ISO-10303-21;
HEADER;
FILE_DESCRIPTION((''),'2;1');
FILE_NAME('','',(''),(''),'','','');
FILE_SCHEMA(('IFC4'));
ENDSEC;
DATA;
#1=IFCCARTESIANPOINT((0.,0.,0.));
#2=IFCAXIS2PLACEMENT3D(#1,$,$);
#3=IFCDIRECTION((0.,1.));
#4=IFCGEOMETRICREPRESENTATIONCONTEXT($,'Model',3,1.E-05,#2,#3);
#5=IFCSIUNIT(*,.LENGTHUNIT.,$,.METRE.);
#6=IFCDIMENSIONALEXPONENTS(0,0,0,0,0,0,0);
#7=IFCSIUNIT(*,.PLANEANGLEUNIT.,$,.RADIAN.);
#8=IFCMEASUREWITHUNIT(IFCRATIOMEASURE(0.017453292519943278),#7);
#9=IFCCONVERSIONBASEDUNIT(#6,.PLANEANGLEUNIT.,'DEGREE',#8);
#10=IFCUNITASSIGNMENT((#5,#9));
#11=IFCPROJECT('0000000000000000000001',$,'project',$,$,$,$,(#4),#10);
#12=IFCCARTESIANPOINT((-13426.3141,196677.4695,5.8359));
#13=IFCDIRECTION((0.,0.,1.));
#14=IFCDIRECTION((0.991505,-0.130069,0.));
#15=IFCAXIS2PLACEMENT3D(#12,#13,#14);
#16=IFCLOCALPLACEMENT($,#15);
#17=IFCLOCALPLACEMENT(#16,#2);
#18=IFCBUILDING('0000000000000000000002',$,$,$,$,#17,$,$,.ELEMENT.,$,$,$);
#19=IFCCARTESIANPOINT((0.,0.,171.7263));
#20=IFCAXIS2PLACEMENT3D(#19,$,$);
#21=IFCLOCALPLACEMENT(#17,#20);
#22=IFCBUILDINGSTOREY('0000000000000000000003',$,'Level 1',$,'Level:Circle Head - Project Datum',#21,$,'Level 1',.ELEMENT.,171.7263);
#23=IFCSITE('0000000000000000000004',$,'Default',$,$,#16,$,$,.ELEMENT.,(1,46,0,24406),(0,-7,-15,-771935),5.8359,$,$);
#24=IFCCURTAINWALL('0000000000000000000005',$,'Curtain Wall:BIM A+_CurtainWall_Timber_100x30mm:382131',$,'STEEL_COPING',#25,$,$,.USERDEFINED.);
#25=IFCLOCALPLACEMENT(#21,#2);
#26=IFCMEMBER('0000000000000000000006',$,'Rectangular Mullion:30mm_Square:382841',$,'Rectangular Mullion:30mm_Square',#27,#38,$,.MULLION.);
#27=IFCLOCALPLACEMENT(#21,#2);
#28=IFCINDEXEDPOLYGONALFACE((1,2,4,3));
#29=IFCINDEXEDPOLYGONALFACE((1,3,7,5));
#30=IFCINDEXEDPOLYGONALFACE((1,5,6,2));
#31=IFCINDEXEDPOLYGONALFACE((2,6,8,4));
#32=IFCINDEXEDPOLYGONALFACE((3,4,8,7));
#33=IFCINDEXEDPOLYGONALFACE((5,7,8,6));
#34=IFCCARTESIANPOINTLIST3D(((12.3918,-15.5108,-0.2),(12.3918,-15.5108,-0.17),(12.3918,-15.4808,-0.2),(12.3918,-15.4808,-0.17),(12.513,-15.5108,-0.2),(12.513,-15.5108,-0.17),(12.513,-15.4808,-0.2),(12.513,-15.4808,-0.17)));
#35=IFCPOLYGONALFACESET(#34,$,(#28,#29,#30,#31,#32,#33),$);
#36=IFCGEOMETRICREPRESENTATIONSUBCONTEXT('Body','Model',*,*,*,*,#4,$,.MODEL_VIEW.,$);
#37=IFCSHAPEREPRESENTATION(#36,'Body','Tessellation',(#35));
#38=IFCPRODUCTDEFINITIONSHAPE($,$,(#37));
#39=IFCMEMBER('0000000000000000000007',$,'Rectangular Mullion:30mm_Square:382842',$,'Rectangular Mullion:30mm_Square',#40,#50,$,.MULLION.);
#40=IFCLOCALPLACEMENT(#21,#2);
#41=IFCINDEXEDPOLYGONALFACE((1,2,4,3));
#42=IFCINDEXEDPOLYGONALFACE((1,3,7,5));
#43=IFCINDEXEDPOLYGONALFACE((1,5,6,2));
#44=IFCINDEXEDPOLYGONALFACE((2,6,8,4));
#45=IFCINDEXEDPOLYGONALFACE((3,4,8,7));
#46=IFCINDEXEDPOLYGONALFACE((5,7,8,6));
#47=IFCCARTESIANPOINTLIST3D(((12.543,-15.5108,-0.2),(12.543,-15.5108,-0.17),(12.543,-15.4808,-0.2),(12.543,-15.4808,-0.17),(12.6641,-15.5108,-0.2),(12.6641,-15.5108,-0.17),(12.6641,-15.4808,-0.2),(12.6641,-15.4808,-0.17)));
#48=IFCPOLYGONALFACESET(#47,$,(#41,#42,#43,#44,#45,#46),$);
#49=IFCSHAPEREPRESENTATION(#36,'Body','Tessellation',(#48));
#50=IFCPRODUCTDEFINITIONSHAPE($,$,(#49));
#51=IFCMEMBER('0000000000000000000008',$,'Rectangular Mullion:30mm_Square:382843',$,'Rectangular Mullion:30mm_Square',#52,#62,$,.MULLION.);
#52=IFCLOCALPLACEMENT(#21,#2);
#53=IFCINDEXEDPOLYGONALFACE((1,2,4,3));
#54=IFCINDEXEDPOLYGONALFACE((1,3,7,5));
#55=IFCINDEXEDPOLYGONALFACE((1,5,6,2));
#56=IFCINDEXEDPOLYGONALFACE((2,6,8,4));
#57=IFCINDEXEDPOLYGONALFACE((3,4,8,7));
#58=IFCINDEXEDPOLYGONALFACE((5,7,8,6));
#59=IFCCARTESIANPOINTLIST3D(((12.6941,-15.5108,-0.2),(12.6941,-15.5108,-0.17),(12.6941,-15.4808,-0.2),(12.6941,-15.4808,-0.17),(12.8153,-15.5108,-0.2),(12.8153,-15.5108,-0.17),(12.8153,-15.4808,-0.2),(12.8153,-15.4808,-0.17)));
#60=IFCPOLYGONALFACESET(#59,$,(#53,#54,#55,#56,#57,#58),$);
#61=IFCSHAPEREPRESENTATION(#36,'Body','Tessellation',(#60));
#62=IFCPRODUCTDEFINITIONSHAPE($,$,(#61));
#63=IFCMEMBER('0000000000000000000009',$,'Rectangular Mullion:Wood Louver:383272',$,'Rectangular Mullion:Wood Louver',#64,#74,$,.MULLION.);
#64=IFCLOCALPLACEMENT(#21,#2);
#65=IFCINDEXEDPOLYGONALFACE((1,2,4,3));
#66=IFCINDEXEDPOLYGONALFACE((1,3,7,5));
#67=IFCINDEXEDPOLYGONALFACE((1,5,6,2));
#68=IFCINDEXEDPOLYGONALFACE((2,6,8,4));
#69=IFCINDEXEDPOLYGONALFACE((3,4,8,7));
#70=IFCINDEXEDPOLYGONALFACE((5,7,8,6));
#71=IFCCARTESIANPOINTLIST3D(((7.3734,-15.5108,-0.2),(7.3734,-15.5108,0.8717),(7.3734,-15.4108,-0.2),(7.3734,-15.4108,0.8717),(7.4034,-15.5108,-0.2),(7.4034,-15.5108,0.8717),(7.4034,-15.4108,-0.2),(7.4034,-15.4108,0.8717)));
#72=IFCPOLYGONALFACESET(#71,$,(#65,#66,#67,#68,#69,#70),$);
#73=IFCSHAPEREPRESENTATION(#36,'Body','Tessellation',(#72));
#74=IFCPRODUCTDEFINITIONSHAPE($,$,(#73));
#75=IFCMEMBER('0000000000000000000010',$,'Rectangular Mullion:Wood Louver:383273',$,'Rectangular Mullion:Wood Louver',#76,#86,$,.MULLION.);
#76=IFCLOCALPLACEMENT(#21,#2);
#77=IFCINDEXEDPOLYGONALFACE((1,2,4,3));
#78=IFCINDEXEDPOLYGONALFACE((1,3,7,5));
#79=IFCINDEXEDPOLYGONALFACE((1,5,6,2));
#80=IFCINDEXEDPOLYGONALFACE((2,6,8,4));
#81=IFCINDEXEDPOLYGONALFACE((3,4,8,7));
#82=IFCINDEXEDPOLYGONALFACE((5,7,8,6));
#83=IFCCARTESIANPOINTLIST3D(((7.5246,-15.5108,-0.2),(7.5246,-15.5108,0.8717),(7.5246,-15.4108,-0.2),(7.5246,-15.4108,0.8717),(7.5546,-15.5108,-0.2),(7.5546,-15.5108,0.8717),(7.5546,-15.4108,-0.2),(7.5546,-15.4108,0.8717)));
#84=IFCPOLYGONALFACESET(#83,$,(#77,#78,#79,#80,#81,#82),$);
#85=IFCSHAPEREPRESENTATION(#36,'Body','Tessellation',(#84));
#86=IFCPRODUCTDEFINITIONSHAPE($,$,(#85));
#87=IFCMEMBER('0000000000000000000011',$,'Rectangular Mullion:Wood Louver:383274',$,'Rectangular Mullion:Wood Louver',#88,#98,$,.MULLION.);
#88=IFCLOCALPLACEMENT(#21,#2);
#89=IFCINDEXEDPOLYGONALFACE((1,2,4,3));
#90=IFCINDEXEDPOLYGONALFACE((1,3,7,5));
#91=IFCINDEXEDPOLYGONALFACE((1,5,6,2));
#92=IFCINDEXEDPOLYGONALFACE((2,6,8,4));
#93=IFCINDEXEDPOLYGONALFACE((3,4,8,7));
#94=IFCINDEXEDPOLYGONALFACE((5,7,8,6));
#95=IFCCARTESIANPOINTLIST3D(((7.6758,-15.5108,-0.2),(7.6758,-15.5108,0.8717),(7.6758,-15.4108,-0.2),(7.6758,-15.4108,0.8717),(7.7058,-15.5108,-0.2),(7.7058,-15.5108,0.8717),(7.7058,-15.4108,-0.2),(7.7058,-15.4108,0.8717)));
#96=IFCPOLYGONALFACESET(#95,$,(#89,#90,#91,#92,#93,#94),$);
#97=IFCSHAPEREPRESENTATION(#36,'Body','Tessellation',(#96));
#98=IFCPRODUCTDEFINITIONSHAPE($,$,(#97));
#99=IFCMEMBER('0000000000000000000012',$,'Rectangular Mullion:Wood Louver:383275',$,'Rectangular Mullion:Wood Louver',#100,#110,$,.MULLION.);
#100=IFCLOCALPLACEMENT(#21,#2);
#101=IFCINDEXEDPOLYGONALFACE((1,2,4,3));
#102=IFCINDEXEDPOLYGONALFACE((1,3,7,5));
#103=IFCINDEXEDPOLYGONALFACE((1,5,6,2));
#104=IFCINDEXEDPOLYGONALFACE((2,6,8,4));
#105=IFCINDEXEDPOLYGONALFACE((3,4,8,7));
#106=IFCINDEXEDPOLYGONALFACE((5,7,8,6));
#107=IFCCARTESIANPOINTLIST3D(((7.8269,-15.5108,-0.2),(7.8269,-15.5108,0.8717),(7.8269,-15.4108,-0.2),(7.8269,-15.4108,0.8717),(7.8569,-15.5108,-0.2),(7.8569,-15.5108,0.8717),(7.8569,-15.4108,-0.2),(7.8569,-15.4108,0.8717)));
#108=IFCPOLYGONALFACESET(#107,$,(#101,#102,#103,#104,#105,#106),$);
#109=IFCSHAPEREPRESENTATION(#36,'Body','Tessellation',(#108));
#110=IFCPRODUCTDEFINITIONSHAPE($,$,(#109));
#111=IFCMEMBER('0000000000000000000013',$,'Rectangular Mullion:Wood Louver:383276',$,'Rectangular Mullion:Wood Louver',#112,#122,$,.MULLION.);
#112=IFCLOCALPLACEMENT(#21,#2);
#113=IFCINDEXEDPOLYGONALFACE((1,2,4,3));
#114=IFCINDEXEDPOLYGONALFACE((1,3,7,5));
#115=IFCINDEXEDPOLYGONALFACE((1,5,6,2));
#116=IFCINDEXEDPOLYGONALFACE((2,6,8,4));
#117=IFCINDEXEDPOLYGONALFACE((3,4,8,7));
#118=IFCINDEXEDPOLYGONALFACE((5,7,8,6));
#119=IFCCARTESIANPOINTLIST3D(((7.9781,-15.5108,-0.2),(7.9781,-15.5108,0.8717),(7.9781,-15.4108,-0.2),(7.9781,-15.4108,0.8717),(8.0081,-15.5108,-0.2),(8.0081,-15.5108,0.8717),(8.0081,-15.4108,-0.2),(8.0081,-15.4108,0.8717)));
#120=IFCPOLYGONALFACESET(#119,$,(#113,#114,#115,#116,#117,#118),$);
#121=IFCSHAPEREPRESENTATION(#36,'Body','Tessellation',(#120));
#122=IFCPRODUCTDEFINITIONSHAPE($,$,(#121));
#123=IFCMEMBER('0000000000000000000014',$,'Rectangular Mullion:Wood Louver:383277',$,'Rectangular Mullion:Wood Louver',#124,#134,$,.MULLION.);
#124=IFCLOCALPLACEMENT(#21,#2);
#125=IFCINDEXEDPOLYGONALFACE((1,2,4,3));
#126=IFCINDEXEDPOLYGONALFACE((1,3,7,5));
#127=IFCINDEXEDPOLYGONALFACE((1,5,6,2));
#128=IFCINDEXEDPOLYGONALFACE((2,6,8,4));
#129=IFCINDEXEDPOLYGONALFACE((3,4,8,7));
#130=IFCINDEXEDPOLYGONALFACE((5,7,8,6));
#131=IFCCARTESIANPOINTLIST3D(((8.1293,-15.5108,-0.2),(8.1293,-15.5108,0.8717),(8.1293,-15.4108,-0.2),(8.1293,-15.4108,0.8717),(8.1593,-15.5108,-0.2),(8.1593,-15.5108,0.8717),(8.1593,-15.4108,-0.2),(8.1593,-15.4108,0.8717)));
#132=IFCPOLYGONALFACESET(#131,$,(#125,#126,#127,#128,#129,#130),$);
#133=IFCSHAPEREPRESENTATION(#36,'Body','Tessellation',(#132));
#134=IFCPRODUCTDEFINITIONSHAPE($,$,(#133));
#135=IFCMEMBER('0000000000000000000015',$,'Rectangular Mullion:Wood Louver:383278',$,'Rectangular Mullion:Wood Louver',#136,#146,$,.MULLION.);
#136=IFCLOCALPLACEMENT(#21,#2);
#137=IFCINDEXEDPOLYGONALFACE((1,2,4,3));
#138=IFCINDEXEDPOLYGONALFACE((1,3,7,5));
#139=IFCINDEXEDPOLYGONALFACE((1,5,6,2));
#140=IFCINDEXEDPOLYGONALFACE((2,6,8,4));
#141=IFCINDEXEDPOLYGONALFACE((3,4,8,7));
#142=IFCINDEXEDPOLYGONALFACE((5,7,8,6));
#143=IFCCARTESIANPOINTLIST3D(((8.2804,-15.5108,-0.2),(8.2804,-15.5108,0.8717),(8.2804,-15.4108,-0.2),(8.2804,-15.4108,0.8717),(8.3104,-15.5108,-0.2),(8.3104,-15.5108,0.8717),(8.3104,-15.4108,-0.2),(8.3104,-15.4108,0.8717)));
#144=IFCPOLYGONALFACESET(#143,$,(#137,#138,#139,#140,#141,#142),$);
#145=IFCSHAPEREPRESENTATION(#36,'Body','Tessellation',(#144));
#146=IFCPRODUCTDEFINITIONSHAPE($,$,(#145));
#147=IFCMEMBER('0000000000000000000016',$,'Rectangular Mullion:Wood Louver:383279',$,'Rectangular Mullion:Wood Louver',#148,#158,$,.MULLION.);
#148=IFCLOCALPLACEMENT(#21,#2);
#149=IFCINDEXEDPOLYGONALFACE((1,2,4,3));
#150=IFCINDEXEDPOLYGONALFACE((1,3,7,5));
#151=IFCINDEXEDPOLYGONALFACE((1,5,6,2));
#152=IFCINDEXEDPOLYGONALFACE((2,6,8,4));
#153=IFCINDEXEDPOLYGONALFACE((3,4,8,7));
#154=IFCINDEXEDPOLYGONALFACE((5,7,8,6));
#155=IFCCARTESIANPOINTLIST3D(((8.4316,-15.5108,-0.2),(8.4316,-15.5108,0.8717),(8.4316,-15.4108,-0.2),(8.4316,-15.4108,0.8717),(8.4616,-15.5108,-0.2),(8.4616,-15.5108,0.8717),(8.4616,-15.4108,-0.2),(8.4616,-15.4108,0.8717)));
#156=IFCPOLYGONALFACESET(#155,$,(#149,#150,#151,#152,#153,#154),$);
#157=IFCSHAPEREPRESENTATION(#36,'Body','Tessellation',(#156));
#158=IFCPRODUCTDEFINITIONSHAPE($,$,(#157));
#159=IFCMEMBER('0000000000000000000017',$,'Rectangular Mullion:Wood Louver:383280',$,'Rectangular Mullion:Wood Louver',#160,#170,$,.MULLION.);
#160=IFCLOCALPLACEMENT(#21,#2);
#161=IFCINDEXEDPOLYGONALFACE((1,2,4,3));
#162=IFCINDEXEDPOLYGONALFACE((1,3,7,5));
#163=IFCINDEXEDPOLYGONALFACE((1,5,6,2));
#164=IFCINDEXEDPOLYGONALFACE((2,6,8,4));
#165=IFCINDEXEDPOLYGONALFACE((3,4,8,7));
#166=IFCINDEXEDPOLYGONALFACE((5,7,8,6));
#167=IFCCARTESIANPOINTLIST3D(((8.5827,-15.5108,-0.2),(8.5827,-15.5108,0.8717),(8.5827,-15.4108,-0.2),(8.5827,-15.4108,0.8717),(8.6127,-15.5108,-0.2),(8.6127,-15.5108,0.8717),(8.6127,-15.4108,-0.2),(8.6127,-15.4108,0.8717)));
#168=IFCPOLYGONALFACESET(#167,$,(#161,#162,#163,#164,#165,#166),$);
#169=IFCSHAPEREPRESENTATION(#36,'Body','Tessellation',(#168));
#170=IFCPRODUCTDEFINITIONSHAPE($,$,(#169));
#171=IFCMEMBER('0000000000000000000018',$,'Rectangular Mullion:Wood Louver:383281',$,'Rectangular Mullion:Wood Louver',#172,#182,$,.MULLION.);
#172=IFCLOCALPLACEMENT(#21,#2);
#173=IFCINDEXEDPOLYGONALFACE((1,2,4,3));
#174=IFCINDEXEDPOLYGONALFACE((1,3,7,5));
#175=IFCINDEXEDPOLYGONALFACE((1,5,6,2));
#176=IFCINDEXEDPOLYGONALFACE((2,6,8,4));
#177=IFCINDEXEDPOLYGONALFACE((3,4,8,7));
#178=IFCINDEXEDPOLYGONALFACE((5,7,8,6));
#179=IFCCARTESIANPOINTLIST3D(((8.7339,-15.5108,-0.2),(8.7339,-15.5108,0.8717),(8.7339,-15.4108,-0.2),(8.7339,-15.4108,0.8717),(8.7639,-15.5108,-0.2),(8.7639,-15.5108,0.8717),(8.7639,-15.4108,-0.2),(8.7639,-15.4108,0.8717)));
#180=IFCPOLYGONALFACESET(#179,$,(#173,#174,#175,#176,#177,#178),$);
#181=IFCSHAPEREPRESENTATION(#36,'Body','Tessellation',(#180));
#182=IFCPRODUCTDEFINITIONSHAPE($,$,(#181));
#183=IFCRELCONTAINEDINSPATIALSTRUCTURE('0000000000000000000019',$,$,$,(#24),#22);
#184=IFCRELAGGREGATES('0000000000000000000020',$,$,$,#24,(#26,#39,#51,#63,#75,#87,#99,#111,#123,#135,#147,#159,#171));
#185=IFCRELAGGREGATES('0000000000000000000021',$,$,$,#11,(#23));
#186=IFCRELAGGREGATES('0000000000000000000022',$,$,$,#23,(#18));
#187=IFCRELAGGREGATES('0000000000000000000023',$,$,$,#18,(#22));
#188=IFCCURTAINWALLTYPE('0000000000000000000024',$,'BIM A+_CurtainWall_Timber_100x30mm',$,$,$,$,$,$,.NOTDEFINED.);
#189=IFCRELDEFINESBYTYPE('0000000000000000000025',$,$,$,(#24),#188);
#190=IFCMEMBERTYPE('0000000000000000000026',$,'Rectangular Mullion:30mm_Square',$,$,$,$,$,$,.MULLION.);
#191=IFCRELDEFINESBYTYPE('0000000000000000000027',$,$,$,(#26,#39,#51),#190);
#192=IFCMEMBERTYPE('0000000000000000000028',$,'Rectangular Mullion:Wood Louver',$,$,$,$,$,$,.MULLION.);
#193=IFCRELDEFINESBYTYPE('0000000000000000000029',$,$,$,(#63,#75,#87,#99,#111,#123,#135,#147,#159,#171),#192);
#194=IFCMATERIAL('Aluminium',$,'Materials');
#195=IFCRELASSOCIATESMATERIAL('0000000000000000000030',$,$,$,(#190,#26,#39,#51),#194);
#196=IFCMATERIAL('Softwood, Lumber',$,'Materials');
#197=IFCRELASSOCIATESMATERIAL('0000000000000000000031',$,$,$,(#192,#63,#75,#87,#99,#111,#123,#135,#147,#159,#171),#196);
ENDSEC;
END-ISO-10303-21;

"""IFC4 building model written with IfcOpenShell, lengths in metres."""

from ifc_helpers import new_model, entity, si_unit, converted_unit, direction, frame, origin, place, context, subcontext, project, spatial, indexed_curve, outline, extrude, source, transform, mapped, material, type_object, type_shapes, element, aggregate, save


model = new_model("IFC4")

# Units and contexts
model_context = context("Model", 3, precision=1e-05, world=origin(), true_north=direction((0.0, 1.0)))
body_context = subcontext(model_context, "Body", "Model", "MODEL_VIEW")
ifc_project = project(units=[si_unit("LENGTHUNIT", "METRE"), converted_unit("PLANEANGLEUNIT", "DEGREE", entity("IfcRatioMeasure", 0.017453292519943278), si_unit("PLANEANGLEUNIT", "RADIAN"), dimensions=[0, 0, 0, 0, 0, 0, 0])], contexts=[model_context])

# Site, building, storey
site_placement = place(None, frame((-13426.3141, 196677.4695, 5.8359), z_axis=(0.0, 0.0, 1.0), x_axis=(0.991505, -0.130069, 0.0)))
site = spatial("IfcSite", under=ifc_project, at=site_placement, Name="Default", CompositionType="ELEMENT", RefLatitude=(1, 46, 0, 24406), RefLongitude=(0, -7, -15, -771935), RefElevation=5.8359)
building_placement = place(site_placement, origin())
building = spatial("IfcBuilding", under=site, at=building_placement, CompositionType="ELEMENT")
storey_placement = place(building_placement, frame((0.0, 0.0, 171.7263)))
storey = spatial("IfcBuildingStorey", under=building, at=storey_placement, Name="Level 1", ObjectType="Level:Circle Head - Project Datum", LongName="Level 1", CompositionType="ELEMENT", Elevation=171.7263)

# Curtain wall, members
curtain_wall_type = type_object("IfcCurtainWallType", Name="BIM A+_CurtainWall_Timber_100x30mm", PredefinedType="NOTDEFINED")
curtain_wall_placement = place(storey_placement, frame((0.0, 0.0, -171.7263)))
curtain_wall = element("IfcCurtainWall", 1, at=curtain_wall_placement, inside=storey, type_object=curtain_wall_type, Name="Curtain Wall:BIM A+_CurtainWall_Timber_100x30mm:382131", ObjectType="STEEL_COPING", PredefinedType="USERDEFINED")
ifc_material_1 = material(Name="Aluminium", Category="Materials")
member_type_1 = type_object("IfcMemberType", Name="Rectangular Mullion:30mm_Square", PredefinedType="MULLION", material=ifc_material_1)
shared_shape_1 = source(origin(), body_context, "Body", "SweptSolid", [
    extrude(outline(indexed_curve([(-0.015, -0.015), (0.015, -0.015), (0.015, 0.015), (-0.015, 0.015), (-0.015, -0.015)], self_intersect=False)), frame((-0.015, 0.0, -0.1212), z_axis=(0.0, 0.0, 1.0), x_axis=(0.0, -1.0, 0.0)), (0.0, 0.0, 1.0), 0.1212),
])
type_shapes(member_type_1, [shared_shape_1])
member_1_placement = place(curtain_wall_placement, frame((12.3918, -15.4958, 171.5263), z_axis=(-1.0, 0.0, 0.0), x_axis=(0.0, 0.0, -1.0)))
member_1 = element("IfcMember", 2, at=member_1_placement, type_object=member_type_1, material=ifc_material_1, Name="Rectangular Mullion:30mm_Square:382841", ObjectType="Rectangular Mullion:30mm_Square", PredefinedType="MULLION", context=body_context, shape_type="MappedRepresentation", body=[
    mapped(shared_shape_1, transform((0.0, 0.0, 0.0), scale=1.0)),
])
member_2_placement = place(curtain_wall_placement, frame((12.543, -15.4958, 171.5263), z_axis=(-1.0, 0.0, 0.0), x_axis=(0.0, 0.0, -1.0)))
member_2 = element("IfcMember", 3, at=member_2_placement, type_object=member_type_1, material=ifc_material_1, Name="Rectangular Mullion:30mm_Square:382842", ObjectType="Rectangular Mullion:30mm_Square", PredefinedType="MULLION", context=body_context, shape_type="MappedRepresentation", body=[
    mapped(shared_shape_1, transform((0.0, 0.0, 0.0), scale=1.0)),
])
member_3_placement = place(curtain_wall_placement, frame((12.6941, -15.4958, 171.5263), z_axis=(-1.0, 0.0, 0.0), x_axis=(0.0, 0.0, -1.0)))
member_3 = element("IfcMember", 4, at=member_3_placement, type_object=member_type_1, material=ifc_material_1, Name="Rectangular Mullion:30mm_Square:382843", ObjectType="Rectangular Mullion:30mm_Square", PredefinedType="MULLION", context=body_context, shape_type="MappedRepresentation", body=[
    mapped(shared_shape_1, transform((0.0, 0.0, 0.0), scale=1.0)),
])
ifc_material_2 = material(Name="Softwood, Lumber", Category="Materials")
member_type_2 = type_object("IfcMemberType", Name="Rectangular Mullion:Wood Louver", PredefinedType="MULLION", material=ifc_material_2)
shared_shape_2 = source(origin(), body_context, "Body", "SweptSolid", [
    extrude(outline(indexed_curve([(-0.05, -0.015), (0.05, -0.015), (0.05, 0.015), (-0.05, 0.015), (-0.05, -0.015)], self_intersect=False)), frame((0.0, -0.035, -1.0717), z_axis=(0.0, 0.0, 1.0), x_axis=(0.0, -1.0, 0.0)), (0.0, 0.0, 1.0), 1.0717),
])
type_shapes(member_type_2, [shared_shape_2])
member_4_placement = place(curtain_wall_placement, frame((7.3884, -15.4958, 171.5263), z_axis=(0.0, 0.0, -1.0), x_axis=(1.0, 0.0, 0.0)))
member_4 = element("IfcMember", 5, at=member_4_placement, type_object=member_type_2, material=ifc_material_2, Name="Rectangular Mullion:Wood Louver:383272", ObjectType="Rectangular Mullion:Wood Louver", PredefinedType="MULLION", context=body_context, shape_type="MappedRepresentation", body=[
    mapped(shared_shape_2, transform((0.0, 0.0, 0.0), scale=1.0)),
])
member_5_placement = place(curtain_wall_placement, frame((7.5396, -15.4958, 171.5263), z_axis=(0.0, 0.0, -1.0), x_axis=(1.0, 0.0, 0.0)))
member_5 = element("IfcMember", 6, at=member_5_placement, type_object=member_type_2, material=ifc_material_2, Name="Rectangular Mullion:Wood Louver:383273", ObjectType="Rectangular Mullion:Wood Louver", PredefinedType="MULLION", context=body_context, shape_type="MappedRepresentation", body=[
    mapped(shared_shape_2, transform((0.0, 0.0, 0.0), scale=1.0)),
])
member_6_placement = place(curtain_wall_placement, frame((7.6908, -15.4958, 171.5263), z_axis=(0.0, 0.0, -1.0), x_axis=(1.0, 0.0, 0.0)))
member_6 = element("IfcMember", 7, at=member_6_placement, type_object=member_type_2, material=ifc_material_2, Name="Rectangular Mullion:Wood Louver:383274", ObjectType="Rectangular Mullion:Wood Louver", PredefinedType="MULLION", context=body_context, shape_type="MappedRepresentation", body=[
    mapped(shared_shape_2, transform((0.0, 0.0, 0.0), scale=1.0)),
])
member_7_placement = place(curtain_wall_placement, frame((7.8419, -15.4958, 171.5263), z_axis=(0.0, 0.0, -1.0), x_axis=(1.0, 0.0, 0.0)))
member_7 = element("IfcMember", 8, at=member_7_placement, type_object=member_type_2, material=ifc_material_2, Name="Rectangular Mullion:Wood Louver:383275", ObjectType="Rectangular Mullion:Wood Louver", PredefinedType="MULLION", context=body_context, shape_type="MappedRepresentation", body=[
    mapped(shared_shape_2, transform((0.0, 0.0, 0.0), scale=1.0)),
])
member_8_placement = place(curtain_wall_placement, frame((7.9931, -15.4958, 171.5263), z_axis=(0.0, 0.0, -1.0), x_axis=(1.0, 0.0, 0.0)))
member_8 = element("IfcMember", 9, at=member_8_placement, type_object=member_type_2, material=ifc_material_2, Name="Rectangular Mullion:Wood Louver:383276", ObjectType="Rectangular Mullion:Wood Louver", PredefinedType="MULLION", context=body_context, shape_type="MappedRepresentation", body=[
    mapped(shared_shape_2, transform((0.0, 0.0, 0.0), scale=1.0)),
])
member_9_placement = place(curtain_wall_placement, frame((8.1443, -15.4958, 171.5263), z_axis=(0.0, 0.0, -1.0), x_axis=(1.0, 0.0, 0.0)))
member_9 = element("IfcMember", 10, at=member_9_placement, type_object=member_type_2, material=ifc_material_2, Name="Rectangular Mullion:Wood Louver:383277", ObjectType="Rectangular Mullion:Wood Louver", PredefinedType="MULLION", context=body_context, shape_type="MappedRepresentation", body=[
    mapped(shared_shape_2, transform((0.0, 0.0, 0.0), scale=1.0)),
])
member_10_placement = place(curtain_wall_placement, frame((8.2954, -15.4958, 171.5263), z_axis=(0.0, 0.0, -1.0), x_axis=(1.0, 0.0, 0.0)))
member_10 = element("IfcMember", 11, at=member_10_placement, type_object=member_type_2, material=ifc_material_2, Name="Rectangular Mullion:Wood Louver:383278", ObjectType="Rectangular Mullion:Wood Louver", PredefinedType="MULLION", context=body_context, shape_type="MappedRepresentation", body=[
    mapped(shared_shape_2, transform((0.0, 0.0, 0.0), scale=1.0)),
])
member_11_placement = place(curtain_wall_placement, frame((8.4466, -15.4958, 171.5263), z_axis=(0.0, 0.0, -1.0), x_axis=(1.0, 0.0, 0.0)))
member_11 = element("IfcMember", 12, at=member_11_placement, type_object=member_type_2, material=ifc_material_2, Name="Rectangular Mullion:Wood Louver:383279", ObjectType="Rectangular Mullion:Wood Louver", PredefinedType="MULLION", context=body_context, shape_type="MappedRepresentation", body=[
    mapped(shared_shape_2, transform((0.0, 0.0, 0.0), scale=1.0)),
])
member_12_placement = place(curtain_wall_placement, frame((8.5977, -15.4958, 171.5263), z_axis=(0.0, 0.0, -1.0), x_axis=(1.0, 0.0, 0.0)))
member_12 = element("IfcMember", 13, at=member_12_placement, type_object=member_type_2, material=ifc_material_2, Name="Rectangular Mullion:Wood Louver:383280", ObjectType="Rectangular Mullion:Wood Louver", PredefinedType="MULLION", context=body_context, shape_type="MappedRepresentation", body=[
    mapped(shared_shape_2, transform((0.0, 0.0, 0.0), scale=1.0)),
])
member_13_placement = place(curtain_wall_placement, frame((8.7489, -15.4958, 171.5263), z_axis=(0.0, 0.0, -1.0), x_axis=(1.0, 0.0, 0.0)))
member_13 = element("IfcMember", 14, at=member_13_placement, type_object=member_type_2, material=ifc_material_2, Name="Rectangular Mullion:Wood Louver:383281", ObjectType="Rectangular Mullion:Wood Louver", PredefinedType="MULLION", context=body_context, shape_type="MappedRepresentation", body=[
    mapped(shared_shape_2, transform((0.0, 0.0, 0.0), scale=1.0)),
])
aggregate(curtain_wall, [member_1, member_2, member_3, member_4, member_5, member_6, member_7, member_8, member_9, member_10, member_11, member_12, member_13])

save(model, "model.ifc")
